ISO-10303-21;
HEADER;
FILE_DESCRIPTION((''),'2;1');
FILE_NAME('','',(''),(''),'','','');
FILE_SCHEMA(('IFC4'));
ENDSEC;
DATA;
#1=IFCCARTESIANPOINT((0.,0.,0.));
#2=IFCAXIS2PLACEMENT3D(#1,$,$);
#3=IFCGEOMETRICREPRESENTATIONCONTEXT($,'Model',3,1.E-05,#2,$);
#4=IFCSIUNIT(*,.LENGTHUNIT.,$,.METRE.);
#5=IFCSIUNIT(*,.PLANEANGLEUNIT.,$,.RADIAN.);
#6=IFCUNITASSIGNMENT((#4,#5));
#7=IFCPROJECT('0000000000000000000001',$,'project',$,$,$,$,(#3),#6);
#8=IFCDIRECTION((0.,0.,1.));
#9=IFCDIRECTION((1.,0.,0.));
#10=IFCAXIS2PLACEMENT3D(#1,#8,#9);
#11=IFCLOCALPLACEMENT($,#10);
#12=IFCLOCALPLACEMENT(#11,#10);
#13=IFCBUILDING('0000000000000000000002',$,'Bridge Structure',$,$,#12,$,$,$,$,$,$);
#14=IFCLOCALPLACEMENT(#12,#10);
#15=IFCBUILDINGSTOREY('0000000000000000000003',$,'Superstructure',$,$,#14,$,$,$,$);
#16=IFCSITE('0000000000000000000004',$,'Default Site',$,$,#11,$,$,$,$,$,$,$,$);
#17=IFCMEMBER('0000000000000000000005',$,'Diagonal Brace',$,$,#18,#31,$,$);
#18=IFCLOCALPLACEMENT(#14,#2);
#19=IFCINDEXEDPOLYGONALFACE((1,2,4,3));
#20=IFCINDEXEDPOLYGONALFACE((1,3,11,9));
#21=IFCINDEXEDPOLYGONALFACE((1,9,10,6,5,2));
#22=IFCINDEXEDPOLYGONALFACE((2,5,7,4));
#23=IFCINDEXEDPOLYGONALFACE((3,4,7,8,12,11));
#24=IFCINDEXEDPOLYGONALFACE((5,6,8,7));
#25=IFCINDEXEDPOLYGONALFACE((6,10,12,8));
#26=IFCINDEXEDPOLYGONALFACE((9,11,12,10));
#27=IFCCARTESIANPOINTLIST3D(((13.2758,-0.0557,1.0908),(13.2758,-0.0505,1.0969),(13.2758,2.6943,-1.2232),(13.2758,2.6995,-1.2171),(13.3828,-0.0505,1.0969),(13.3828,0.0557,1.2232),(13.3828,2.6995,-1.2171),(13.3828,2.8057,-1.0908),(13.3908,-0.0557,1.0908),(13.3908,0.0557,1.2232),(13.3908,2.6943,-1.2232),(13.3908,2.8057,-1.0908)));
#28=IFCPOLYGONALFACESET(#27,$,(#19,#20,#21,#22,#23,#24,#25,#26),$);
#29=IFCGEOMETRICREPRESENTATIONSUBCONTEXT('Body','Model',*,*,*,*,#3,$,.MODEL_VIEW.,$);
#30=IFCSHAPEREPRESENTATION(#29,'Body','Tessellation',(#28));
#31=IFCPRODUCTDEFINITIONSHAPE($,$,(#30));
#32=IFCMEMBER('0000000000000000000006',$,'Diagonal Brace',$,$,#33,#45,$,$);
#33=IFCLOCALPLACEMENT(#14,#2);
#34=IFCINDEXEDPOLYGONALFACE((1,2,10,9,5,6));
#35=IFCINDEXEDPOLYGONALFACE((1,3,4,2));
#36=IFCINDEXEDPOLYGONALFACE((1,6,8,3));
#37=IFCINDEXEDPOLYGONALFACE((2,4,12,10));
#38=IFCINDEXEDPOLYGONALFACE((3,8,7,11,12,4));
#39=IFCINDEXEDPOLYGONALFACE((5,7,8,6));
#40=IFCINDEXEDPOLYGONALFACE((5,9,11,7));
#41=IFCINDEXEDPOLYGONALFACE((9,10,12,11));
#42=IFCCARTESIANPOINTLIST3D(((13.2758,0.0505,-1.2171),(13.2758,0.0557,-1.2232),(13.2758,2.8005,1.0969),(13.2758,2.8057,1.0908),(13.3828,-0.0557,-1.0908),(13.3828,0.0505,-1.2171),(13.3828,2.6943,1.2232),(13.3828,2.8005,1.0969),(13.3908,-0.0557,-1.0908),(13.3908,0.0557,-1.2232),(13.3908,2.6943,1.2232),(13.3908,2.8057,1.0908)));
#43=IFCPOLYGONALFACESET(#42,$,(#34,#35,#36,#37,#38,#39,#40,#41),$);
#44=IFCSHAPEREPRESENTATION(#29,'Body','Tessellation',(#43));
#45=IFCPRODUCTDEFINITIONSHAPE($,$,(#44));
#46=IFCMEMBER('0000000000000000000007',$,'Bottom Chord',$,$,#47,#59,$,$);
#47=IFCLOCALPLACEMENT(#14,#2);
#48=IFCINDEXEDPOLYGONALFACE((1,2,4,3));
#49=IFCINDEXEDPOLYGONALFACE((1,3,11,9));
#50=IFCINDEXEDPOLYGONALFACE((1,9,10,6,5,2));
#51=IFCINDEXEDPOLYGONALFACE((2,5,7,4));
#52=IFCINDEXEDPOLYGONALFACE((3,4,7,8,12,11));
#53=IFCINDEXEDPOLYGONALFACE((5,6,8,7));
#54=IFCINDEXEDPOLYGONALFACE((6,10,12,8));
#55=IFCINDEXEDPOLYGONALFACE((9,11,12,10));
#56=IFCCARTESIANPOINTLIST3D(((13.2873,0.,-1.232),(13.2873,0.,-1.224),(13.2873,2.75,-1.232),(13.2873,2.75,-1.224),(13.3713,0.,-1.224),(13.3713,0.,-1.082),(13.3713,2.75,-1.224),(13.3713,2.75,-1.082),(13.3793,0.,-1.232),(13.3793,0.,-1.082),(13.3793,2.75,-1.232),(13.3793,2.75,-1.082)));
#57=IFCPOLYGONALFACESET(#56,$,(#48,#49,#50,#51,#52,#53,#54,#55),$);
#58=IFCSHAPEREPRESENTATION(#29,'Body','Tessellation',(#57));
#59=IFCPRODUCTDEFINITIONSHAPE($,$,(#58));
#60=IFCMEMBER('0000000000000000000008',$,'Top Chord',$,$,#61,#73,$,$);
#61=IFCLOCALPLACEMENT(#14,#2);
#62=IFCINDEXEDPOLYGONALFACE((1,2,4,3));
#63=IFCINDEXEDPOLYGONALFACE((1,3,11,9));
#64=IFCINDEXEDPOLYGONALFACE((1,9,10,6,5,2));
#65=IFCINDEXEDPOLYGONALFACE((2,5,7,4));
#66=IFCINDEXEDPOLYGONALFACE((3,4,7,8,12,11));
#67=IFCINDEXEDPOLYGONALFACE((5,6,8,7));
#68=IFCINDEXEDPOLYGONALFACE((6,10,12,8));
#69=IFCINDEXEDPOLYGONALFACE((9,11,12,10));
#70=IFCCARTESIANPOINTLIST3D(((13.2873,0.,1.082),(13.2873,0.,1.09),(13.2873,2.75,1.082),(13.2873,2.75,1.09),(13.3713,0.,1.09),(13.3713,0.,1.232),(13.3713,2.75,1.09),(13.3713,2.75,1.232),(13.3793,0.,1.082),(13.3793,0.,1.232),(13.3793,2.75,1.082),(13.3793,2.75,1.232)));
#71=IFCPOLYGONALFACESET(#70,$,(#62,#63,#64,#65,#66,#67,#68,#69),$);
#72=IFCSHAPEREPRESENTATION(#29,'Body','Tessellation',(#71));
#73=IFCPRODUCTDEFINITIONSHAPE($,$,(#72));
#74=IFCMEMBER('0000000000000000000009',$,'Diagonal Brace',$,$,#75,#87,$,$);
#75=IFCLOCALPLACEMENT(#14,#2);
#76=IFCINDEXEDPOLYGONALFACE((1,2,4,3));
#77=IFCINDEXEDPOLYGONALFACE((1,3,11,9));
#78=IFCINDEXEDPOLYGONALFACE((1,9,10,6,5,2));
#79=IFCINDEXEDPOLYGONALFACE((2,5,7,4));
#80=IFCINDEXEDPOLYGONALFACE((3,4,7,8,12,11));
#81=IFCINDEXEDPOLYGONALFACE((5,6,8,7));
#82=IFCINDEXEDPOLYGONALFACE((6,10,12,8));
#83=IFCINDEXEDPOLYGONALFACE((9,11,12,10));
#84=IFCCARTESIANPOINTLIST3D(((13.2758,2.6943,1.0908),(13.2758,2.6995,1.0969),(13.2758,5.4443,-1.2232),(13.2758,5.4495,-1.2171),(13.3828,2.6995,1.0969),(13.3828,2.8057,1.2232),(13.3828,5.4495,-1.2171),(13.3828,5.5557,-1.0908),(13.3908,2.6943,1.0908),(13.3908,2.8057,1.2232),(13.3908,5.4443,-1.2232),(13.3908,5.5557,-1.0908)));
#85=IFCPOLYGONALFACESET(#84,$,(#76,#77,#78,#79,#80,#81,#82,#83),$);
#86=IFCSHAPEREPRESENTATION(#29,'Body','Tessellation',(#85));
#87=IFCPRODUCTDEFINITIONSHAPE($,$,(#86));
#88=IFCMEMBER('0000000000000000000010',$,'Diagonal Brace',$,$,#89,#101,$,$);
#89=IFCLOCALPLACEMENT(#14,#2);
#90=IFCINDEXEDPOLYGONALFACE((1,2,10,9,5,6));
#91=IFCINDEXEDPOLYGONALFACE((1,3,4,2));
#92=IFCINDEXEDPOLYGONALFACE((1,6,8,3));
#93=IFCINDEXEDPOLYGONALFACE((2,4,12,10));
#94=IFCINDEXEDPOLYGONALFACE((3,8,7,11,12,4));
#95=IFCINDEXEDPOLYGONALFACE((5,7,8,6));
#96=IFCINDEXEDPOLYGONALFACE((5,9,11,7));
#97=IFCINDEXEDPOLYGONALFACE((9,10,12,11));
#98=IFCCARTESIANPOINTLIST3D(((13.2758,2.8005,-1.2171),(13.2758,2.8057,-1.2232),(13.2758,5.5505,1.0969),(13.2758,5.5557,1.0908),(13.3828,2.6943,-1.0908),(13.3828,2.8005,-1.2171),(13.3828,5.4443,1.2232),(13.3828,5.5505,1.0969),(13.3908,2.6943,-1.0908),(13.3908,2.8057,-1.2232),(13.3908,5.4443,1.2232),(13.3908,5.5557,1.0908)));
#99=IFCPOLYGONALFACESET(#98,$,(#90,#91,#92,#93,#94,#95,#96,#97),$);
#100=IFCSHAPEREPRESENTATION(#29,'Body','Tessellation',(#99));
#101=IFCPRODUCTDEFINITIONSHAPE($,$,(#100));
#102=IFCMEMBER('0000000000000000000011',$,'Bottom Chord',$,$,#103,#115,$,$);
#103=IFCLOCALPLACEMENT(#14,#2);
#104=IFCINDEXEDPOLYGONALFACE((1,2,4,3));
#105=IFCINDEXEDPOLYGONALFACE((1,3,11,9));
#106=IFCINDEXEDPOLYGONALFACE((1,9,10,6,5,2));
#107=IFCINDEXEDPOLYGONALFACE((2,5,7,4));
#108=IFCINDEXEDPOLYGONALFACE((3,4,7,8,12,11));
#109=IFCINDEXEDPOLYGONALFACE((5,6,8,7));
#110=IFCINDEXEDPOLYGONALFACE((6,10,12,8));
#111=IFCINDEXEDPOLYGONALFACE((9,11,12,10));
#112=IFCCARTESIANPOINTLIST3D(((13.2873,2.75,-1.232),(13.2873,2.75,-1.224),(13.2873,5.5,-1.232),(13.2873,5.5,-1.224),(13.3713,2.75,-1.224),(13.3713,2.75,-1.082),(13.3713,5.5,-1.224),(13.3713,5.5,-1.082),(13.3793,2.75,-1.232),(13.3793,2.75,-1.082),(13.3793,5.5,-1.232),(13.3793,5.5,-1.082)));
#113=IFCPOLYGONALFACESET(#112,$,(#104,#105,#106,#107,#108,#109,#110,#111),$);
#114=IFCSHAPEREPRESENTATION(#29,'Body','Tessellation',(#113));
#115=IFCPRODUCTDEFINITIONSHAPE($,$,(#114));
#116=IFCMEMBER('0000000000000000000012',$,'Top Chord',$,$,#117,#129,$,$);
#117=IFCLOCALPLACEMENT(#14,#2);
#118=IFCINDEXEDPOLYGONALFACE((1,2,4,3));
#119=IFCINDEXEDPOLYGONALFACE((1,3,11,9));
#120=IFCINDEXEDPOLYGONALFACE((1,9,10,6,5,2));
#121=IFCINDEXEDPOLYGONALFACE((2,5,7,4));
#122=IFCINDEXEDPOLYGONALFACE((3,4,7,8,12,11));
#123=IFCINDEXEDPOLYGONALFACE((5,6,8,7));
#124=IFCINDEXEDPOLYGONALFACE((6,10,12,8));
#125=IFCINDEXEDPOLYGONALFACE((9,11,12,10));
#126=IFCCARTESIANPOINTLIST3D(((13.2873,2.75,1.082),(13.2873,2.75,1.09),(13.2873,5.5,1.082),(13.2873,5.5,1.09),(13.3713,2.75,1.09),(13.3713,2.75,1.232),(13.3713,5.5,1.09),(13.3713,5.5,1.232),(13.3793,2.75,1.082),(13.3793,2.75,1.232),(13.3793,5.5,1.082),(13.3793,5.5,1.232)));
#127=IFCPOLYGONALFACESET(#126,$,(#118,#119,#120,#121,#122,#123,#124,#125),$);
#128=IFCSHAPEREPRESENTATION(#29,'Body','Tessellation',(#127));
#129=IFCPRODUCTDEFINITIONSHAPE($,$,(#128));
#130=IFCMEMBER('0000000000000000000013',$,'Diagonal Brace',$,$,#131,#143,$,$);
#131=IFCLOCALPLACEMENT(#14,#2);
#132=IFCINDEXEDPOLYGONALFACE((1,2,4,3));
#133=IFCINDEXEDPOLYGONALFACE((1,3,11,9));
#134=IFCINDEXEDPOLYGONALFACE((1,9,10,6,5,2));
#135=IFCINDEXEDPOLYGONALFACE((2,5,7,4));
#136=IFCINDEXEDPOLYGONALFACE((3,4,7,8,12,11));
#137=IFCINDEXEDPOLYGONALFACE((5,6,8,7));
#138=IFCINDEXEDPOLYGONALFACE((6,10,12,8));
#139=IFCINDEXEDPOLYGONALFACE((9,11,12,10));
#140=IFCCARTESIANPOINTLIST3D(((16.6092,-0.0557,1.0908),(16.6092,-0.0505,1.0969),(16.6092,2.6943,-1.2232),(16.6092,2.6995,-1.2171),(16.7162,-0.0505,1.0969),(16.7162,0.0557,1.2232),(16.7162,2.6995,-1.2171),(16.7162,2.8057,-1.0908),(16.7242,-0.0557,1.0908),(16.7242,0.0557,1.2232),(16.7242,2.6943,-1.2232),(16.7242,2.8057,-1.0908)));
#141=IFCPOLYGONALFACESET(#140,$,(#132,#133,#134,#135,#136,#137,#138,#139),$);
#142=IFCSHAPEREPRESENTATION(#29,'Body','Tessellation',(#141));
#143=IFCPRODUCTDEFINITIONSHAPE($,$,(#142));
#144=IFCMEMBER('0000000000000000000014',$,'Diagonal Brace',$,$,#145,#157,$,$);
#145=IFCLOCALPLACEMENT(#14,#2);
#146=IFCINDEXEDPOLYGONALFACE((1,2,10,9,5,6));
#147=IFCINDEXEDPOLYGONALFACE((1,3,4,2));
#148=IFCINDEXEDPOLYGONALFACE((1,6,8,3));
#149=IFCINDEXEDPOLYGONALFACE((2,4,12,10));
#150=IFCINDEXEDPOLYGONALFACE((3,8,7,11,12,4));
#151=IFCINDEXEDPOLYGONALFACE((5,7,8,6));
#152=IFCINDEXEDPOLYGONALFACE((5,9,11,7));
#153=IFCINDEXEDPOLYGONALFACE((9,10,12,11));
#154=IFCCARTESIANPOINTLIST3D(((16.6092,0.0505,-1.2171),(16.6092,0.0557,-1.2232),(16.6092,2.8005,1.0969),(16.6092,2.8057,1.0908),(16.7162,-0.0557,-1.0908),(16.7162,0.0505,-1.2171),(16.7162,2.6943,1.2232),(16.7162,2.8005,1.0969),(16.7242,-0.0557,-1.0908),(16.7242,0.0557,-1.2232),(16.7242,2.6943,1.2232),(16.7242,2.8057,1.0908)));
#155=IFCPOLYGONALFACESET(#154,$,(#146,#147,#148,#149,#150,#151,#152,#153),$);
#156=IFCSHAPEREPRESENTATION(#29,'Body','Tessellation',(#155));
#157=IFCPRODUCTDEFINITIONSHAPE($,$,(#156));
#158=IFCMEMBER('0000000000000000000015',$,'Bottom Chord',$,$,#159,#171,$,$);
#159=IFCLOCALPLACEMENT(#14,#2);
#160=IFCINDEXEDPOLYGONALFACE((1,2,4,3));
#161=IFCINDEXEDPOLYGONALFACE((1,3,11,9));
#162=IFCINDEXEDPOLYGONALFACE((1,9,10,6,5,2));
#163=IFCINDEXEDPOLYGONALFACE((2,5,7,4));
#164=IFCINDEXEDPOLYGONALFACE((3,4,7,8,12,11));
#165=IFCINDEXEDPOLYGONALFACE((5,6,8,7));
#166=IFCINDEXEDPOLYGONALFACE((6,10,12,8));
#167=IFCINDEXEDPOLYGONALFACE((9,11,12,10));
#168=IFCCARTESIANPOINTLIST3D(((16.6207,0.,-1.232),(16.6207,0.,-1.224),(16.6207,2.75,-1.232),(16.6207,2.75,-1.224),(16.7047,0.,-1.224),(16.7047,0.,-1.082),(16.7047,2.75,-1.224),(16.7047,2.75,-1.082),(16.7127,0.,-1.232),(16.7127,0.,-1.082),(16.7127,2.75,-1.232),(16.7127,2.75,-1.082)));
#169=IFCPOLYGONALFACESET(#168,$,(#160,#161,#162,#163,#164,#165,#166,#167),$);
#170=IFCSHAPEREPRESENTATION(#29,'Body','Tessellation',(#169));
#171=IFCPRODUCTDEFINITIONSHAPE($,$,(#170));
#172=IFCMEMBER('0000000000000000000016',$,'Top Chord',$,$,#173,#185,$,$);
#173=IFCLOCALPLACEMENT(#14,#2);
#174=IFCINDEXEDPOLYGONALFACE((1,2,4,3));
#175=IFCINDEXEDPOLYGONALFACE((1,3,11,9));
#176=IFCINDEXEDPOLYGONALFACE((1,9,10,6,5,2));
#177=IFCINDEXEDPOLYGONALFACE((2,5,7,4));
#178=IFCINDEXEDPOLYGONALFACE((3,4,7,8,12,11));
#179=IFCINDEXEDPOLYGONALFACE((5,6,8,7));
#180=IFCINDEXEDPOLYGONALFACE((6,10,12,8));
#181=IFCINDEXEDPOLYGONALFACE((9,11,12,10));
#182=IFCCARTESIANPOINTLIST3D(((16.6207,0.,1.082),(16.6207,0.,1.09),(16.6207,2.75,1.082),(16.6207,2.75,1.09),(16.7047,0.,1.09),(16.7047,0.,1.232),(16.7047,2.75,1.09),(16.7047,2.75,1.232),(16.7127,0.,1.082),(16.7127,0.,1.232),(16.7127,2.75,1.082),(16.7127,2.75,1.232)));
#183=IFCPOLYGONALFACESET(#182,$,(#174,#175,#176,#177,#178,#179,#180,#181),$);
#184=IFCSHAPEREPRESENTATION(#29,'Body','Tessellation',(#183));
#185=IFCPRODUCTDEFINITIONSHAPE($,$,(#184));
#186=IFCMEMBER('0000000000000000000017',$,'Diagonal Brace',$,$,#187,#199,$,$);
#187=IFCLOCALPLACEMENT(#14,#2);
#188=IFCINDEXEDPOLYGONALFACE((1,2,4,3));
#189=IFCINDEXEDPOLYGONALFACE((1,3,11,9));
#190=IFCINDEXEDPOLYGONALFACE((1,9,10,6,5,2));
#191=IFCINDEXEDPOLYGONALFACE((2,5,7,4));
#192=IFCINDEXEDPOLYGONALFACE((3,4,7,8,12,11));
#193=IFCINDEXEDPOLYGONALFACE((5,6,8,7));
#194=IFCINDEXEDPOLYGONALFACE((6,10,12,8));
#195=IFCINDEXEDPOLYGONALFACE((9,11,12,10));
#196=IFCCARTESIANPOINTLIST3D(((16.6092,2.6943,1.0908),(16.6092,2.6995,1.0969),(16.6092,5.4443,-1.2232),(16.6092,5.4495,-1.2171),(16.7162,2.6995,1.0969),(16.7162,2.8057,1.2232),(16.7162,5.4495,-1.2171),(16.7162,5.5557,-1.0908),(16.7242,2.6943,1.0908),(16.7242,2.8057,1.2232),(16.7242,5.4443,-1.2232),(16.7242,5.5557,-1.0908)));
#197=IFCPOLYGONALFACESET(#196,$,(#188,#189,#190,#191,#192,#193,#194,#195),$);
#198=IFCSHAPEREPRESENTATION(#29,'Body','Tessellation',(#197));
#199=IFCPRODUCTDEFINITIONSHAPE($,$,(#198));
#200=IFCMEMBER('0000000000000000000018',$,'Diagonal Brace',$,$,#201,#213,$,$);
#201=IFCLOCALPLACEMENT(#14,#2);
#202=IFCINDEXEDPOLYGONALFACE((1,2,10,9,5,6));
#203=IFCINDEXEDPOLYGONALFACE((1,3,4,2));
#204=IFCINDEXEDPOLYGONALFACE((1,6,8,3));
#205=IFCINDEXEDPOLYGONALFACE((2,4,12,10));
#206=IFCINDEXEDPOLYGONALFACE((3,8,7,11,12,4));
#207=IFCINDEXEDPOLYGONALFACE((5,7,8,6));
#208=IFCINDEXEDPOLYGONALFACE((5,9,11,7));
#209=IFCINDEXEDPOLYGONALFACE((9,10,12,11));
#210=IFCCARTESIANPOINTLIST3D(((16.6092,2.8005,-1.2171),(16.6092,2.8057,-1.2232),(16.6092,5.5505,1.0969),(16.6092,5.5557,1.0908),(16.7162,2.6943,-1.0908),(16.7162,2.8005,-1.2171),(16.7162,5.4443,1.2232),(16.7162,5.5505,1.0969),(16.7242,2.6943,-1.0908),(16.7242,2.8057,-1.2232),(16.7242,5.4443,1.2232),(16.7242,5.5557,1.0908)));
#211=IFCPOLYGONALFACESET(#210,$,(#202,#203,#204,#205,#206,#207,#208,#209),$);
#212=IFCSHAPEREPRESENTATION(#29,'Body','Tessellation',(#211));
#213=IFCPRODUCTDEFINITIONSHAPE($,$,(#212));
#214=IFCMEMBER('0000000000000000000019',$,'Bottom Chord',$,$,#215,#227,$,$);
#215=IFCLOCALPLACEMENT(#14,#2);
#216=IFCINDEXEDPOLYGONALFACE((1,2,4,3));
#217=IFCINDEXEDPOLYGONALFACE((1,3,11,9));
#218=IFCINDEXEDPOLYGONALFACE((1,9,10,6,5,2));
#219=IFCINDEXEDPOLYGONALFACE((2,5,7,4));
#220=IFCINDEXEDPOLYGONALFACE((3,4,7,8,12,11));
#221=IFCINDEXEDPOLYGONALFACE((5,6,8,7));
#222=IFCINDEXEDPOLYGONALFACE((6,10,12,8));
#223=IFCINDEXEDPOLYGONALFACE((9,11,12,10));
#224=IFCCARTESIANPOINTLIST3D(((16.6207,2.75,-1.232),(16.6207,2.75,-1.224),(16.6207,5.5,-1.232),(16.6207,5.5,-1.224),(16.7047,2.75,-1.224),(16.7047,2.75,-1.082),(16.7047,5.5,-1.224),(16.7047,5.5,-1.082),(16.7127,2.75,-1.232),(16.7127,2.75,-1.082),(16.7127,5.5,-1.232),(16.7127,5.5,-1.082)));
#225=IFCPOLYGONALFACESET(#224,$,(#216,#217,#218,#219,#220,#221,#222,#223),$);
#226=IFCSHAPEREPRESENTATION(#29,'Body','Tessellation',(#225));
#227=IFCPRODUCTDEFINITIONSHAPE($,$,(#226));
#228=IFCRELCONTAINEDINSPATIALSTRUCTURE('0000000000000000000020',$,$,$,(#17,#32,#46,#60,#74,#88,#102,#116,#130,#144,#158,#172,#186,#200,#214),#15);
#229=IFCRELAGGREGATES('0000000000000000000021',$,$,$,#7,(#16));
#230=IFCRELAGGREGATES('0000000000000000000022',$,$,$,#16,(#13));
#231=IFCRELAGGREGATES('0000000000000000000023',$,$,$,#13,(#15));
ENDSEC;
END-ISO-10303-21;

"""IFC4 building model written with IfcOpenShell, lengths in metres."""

from ifc_helpers import new_model, si_unit, frame, origin, origin_with_axes, origin_2d_with_axis, place, context, subcontext, project, spatial, l_section, extrude, element, save


model = new_model("IFC4")

# Units and contexts
model_context = context("Model", 3, precision=1e-05, world=origin())
body_context = subcontext(model_context, "Body", "Model", "MODEL_VIEW")
ifc_project = project(units=[si_unit("LENGTHUNIT", "METRE"), si_unit("PLANEANGLEUNIT", "RADIAN")], contexts=[model_context])

# Site, building, storey
site_placement = place(None, origin_with_axes())
site = spatial("IfcSite", under=ifc_project, at=site_placement, Name="Default Site")
building_placement = place(site_placement, origin_with_axes())
building = spatial("IfcBuilding", under=site, at=building_placement, Name="Bridge Structure")
storey_placement = place(building_placement, origin_with_axes())
storey = spatial("IfcBuildingStorey", under=building, at=storey_placement, Name="Superstructure")

# Members
for number, where, z_axis, x_axis, name in (
    (1, (13.3333, 0.0, 1.157), (0.0, 0.765156, -0.643844), (-1.0, 0.0, 0.0), "Diagonal Brace"),
    (2, (13.3333, 0.0, -1.157), (0.0, 0.765156, 0.643844), (-1.0, 0.0, 0.0), "Diagonal Brace"),
):
    element("IfcMember", number, at=place(storey_placement, frame(where, z_axis=z_axis, x_axis=x_axis)), inside=storey, Name=name, context=body_context, shape_type="SweptSolid", body=[
        extrude(l_section(Depth=0.173, Width=0.115, Thickness=0.008, at=origin_2d_with_axis()), origin_with_axes(), (0.0, 0.0, 1.0), 3.594),
    ])
for number, where, z_axis, x_axis, name in (
    (3, (13.3333, 0.0, -1.157), (0.0, 1.0, 0.0), (-1.0, 0.0, 0.0), "Bottom Chord"),
    (4, (13.3333, 0.0, 1.157), (0.0, 1.0, 0.0), (-1.0, 0.0, 0.0), "Top Chord"),
):
    element("IfcMember", number, at=place(storey_placement, frame(where, z_axis=z_axis, x_axis=x_axis)), inside=storey, Name=name, context=body_context, shape_type="SweptSolid", body=[
        extrude(l_section(Depth=0.15, Width=0.092, Thickness=0.008, at=origin_2d_with_axis()), origin_with_axes(), (0.0, 0.0, 1.0), 2.75),
    ])
for number, where, z_axis, x_axis, name in (
    (5, (13.3333, 2.75, 1.157), (0.0, 0.765156, -0.643844), (-1.0, 0.0, 0.0), "Diagonal Brace"),
    (6, (13.3333, 2.75, -1.157), (0.0, 0.765156, 0.643844), (-1.0, 0.0, 0.0), "Diagonal Brace"),
):
    element("IfcMember", number, at=place(storey_placement, frame(where, z_axis=z_axis, x_axis=x_axis)), inside=storey, Name=name, context=body_context, shape_type="SweptSolid", body=[
        extrude(l_section(Depth=0.173, Width=0.115, Thickness=0.008, at=origin_2d_with_axis()), origin_with_axes(), (0.0, 0.0, 1.0), 3.594),
    ])
for number, where, z_axis, x_axis, name in (
    (7, (13.3333, 2.75, -1.157), (0.0, 1.0, 0.0), (-1.0, 0.0, 0.0), "Bottom Chord"),
    (8, (13.3333, 2.75, 1.157), (0.0, 1.0, 0.0), (-1.0, 0.0, 0.0), "Top Chord"),
):
    element("IfcMember", number, at=place(storey_placement, frame(where, z_axis=z_axis, x_axis=x_axis)), inside=storey, Name=name, context=body_context, shape_type="SweptSolid", body=[
        extrude(l_section(Depth=0.15, Width=0.092, Thickness=0.008, at=origin_2d_with_axis()), origin_with_axes(), (0.0, 0.0, 1.0), 2.75),
    ])
for number, where, z_axis, x_axis, name in (
    (9, (16.6667, 0.0, 1.157), (0.0, 0.765156, -0.643844), (-1.0, 0.0, 0.0), "Diagonal Brace"),
    (10, (16.6667, 0.0, -1.157), (0.0, 0.765156, 0.643844), (-1.0, 0.0, 0.0), "Diagonal Brace"),
):
    element("IfcMember", number, at=place(storey_placement, frame(where, z_axis=z_axis, x_axis=x_axis)), inside=storey, Name=name, context=body_context, shape_type="SweptSolid", body=[
        extrude(l_section(Depth=0.173, Width=0.115, Thickness=0.008, at=origin_2d_with_axis()), origin_with_axes(), (0.0, 0.0, 1.0), 3.594),
    ])
for number, where, z_axis, x_axis, name in (
    (11, (16.6667, 0.0, -1.157), (0.0, 1.0, 0.0), (-1.0, 0.0, 0.0), "Bottom Chord"),
    (12, (16.6667, 0.0, 1.157), (0.0, 1.0, 0.0), (-1.0, 0.0, 0.0), "Top Chord"),
):
    element("IfcMember", number, at=place(storey_placement, frame(where, z_axis=z_axis, x_axis=x_axis)), inside=storey, Name=name, context=body_context, shape_type="SweptSolid", body=[
        extrude(l_section(Depth=0.15, Width=0.092, Thickness=0.008, at=origin_2d_with_axis()), origin_with_axes(), (0.0, 0.0, 1.0), 2.75),
    ])
for number, where, z_axis, x_axis, name in (
    (13, (16.6667, 2.75, 1.157), (0.0, 0.765156, -0.643844), (-1.0, 0.0, 0.0), "Diagonal Brace"),
    (14, (16.6667, 2.75, -1.157), (0.0, 0.765156, 0.643844), (-1.0, 0.0, 0.0), "Diagonal Brace"),
):
    element("IfcMember", number, at=place(storey_placement, frame(where, z_axis=z_axis, x_axis=x_axis)), inside=storey, Name=name, context=body_context, shape_type="SweptSolid", body=[
        extrude(l_section(Depth=0.173, Width=0.115, Thickness=0.008, at=origin_2d_with_axis()), origin_with_axes(), (0.0, 0.0, 1.0), 3.594),
    ])
for number, where, z_axis, x_axis, name in (
    (15, (16.6667, 2.75, -1.157), (0.0, 1.0, 0.0), (-1.0, 0.0, 0.0), "Bottom Chord"),
):
    element("IfcMember", number, at=place(storey_placement, frame(where, z_axis=z_axis, x_axis=x_axis)), inside=storey, Name=name, context=body_context, shape_type="SweptSolid", body=[
        extrude(l_section(Depth=0.15, Width=0.092, Thickness=0.008, at=origin_2d_with_axis()), origin_with_axes(), (0.0, 0.0, 1.0), 2.75),
    ])

save(model, "model.ifc")
